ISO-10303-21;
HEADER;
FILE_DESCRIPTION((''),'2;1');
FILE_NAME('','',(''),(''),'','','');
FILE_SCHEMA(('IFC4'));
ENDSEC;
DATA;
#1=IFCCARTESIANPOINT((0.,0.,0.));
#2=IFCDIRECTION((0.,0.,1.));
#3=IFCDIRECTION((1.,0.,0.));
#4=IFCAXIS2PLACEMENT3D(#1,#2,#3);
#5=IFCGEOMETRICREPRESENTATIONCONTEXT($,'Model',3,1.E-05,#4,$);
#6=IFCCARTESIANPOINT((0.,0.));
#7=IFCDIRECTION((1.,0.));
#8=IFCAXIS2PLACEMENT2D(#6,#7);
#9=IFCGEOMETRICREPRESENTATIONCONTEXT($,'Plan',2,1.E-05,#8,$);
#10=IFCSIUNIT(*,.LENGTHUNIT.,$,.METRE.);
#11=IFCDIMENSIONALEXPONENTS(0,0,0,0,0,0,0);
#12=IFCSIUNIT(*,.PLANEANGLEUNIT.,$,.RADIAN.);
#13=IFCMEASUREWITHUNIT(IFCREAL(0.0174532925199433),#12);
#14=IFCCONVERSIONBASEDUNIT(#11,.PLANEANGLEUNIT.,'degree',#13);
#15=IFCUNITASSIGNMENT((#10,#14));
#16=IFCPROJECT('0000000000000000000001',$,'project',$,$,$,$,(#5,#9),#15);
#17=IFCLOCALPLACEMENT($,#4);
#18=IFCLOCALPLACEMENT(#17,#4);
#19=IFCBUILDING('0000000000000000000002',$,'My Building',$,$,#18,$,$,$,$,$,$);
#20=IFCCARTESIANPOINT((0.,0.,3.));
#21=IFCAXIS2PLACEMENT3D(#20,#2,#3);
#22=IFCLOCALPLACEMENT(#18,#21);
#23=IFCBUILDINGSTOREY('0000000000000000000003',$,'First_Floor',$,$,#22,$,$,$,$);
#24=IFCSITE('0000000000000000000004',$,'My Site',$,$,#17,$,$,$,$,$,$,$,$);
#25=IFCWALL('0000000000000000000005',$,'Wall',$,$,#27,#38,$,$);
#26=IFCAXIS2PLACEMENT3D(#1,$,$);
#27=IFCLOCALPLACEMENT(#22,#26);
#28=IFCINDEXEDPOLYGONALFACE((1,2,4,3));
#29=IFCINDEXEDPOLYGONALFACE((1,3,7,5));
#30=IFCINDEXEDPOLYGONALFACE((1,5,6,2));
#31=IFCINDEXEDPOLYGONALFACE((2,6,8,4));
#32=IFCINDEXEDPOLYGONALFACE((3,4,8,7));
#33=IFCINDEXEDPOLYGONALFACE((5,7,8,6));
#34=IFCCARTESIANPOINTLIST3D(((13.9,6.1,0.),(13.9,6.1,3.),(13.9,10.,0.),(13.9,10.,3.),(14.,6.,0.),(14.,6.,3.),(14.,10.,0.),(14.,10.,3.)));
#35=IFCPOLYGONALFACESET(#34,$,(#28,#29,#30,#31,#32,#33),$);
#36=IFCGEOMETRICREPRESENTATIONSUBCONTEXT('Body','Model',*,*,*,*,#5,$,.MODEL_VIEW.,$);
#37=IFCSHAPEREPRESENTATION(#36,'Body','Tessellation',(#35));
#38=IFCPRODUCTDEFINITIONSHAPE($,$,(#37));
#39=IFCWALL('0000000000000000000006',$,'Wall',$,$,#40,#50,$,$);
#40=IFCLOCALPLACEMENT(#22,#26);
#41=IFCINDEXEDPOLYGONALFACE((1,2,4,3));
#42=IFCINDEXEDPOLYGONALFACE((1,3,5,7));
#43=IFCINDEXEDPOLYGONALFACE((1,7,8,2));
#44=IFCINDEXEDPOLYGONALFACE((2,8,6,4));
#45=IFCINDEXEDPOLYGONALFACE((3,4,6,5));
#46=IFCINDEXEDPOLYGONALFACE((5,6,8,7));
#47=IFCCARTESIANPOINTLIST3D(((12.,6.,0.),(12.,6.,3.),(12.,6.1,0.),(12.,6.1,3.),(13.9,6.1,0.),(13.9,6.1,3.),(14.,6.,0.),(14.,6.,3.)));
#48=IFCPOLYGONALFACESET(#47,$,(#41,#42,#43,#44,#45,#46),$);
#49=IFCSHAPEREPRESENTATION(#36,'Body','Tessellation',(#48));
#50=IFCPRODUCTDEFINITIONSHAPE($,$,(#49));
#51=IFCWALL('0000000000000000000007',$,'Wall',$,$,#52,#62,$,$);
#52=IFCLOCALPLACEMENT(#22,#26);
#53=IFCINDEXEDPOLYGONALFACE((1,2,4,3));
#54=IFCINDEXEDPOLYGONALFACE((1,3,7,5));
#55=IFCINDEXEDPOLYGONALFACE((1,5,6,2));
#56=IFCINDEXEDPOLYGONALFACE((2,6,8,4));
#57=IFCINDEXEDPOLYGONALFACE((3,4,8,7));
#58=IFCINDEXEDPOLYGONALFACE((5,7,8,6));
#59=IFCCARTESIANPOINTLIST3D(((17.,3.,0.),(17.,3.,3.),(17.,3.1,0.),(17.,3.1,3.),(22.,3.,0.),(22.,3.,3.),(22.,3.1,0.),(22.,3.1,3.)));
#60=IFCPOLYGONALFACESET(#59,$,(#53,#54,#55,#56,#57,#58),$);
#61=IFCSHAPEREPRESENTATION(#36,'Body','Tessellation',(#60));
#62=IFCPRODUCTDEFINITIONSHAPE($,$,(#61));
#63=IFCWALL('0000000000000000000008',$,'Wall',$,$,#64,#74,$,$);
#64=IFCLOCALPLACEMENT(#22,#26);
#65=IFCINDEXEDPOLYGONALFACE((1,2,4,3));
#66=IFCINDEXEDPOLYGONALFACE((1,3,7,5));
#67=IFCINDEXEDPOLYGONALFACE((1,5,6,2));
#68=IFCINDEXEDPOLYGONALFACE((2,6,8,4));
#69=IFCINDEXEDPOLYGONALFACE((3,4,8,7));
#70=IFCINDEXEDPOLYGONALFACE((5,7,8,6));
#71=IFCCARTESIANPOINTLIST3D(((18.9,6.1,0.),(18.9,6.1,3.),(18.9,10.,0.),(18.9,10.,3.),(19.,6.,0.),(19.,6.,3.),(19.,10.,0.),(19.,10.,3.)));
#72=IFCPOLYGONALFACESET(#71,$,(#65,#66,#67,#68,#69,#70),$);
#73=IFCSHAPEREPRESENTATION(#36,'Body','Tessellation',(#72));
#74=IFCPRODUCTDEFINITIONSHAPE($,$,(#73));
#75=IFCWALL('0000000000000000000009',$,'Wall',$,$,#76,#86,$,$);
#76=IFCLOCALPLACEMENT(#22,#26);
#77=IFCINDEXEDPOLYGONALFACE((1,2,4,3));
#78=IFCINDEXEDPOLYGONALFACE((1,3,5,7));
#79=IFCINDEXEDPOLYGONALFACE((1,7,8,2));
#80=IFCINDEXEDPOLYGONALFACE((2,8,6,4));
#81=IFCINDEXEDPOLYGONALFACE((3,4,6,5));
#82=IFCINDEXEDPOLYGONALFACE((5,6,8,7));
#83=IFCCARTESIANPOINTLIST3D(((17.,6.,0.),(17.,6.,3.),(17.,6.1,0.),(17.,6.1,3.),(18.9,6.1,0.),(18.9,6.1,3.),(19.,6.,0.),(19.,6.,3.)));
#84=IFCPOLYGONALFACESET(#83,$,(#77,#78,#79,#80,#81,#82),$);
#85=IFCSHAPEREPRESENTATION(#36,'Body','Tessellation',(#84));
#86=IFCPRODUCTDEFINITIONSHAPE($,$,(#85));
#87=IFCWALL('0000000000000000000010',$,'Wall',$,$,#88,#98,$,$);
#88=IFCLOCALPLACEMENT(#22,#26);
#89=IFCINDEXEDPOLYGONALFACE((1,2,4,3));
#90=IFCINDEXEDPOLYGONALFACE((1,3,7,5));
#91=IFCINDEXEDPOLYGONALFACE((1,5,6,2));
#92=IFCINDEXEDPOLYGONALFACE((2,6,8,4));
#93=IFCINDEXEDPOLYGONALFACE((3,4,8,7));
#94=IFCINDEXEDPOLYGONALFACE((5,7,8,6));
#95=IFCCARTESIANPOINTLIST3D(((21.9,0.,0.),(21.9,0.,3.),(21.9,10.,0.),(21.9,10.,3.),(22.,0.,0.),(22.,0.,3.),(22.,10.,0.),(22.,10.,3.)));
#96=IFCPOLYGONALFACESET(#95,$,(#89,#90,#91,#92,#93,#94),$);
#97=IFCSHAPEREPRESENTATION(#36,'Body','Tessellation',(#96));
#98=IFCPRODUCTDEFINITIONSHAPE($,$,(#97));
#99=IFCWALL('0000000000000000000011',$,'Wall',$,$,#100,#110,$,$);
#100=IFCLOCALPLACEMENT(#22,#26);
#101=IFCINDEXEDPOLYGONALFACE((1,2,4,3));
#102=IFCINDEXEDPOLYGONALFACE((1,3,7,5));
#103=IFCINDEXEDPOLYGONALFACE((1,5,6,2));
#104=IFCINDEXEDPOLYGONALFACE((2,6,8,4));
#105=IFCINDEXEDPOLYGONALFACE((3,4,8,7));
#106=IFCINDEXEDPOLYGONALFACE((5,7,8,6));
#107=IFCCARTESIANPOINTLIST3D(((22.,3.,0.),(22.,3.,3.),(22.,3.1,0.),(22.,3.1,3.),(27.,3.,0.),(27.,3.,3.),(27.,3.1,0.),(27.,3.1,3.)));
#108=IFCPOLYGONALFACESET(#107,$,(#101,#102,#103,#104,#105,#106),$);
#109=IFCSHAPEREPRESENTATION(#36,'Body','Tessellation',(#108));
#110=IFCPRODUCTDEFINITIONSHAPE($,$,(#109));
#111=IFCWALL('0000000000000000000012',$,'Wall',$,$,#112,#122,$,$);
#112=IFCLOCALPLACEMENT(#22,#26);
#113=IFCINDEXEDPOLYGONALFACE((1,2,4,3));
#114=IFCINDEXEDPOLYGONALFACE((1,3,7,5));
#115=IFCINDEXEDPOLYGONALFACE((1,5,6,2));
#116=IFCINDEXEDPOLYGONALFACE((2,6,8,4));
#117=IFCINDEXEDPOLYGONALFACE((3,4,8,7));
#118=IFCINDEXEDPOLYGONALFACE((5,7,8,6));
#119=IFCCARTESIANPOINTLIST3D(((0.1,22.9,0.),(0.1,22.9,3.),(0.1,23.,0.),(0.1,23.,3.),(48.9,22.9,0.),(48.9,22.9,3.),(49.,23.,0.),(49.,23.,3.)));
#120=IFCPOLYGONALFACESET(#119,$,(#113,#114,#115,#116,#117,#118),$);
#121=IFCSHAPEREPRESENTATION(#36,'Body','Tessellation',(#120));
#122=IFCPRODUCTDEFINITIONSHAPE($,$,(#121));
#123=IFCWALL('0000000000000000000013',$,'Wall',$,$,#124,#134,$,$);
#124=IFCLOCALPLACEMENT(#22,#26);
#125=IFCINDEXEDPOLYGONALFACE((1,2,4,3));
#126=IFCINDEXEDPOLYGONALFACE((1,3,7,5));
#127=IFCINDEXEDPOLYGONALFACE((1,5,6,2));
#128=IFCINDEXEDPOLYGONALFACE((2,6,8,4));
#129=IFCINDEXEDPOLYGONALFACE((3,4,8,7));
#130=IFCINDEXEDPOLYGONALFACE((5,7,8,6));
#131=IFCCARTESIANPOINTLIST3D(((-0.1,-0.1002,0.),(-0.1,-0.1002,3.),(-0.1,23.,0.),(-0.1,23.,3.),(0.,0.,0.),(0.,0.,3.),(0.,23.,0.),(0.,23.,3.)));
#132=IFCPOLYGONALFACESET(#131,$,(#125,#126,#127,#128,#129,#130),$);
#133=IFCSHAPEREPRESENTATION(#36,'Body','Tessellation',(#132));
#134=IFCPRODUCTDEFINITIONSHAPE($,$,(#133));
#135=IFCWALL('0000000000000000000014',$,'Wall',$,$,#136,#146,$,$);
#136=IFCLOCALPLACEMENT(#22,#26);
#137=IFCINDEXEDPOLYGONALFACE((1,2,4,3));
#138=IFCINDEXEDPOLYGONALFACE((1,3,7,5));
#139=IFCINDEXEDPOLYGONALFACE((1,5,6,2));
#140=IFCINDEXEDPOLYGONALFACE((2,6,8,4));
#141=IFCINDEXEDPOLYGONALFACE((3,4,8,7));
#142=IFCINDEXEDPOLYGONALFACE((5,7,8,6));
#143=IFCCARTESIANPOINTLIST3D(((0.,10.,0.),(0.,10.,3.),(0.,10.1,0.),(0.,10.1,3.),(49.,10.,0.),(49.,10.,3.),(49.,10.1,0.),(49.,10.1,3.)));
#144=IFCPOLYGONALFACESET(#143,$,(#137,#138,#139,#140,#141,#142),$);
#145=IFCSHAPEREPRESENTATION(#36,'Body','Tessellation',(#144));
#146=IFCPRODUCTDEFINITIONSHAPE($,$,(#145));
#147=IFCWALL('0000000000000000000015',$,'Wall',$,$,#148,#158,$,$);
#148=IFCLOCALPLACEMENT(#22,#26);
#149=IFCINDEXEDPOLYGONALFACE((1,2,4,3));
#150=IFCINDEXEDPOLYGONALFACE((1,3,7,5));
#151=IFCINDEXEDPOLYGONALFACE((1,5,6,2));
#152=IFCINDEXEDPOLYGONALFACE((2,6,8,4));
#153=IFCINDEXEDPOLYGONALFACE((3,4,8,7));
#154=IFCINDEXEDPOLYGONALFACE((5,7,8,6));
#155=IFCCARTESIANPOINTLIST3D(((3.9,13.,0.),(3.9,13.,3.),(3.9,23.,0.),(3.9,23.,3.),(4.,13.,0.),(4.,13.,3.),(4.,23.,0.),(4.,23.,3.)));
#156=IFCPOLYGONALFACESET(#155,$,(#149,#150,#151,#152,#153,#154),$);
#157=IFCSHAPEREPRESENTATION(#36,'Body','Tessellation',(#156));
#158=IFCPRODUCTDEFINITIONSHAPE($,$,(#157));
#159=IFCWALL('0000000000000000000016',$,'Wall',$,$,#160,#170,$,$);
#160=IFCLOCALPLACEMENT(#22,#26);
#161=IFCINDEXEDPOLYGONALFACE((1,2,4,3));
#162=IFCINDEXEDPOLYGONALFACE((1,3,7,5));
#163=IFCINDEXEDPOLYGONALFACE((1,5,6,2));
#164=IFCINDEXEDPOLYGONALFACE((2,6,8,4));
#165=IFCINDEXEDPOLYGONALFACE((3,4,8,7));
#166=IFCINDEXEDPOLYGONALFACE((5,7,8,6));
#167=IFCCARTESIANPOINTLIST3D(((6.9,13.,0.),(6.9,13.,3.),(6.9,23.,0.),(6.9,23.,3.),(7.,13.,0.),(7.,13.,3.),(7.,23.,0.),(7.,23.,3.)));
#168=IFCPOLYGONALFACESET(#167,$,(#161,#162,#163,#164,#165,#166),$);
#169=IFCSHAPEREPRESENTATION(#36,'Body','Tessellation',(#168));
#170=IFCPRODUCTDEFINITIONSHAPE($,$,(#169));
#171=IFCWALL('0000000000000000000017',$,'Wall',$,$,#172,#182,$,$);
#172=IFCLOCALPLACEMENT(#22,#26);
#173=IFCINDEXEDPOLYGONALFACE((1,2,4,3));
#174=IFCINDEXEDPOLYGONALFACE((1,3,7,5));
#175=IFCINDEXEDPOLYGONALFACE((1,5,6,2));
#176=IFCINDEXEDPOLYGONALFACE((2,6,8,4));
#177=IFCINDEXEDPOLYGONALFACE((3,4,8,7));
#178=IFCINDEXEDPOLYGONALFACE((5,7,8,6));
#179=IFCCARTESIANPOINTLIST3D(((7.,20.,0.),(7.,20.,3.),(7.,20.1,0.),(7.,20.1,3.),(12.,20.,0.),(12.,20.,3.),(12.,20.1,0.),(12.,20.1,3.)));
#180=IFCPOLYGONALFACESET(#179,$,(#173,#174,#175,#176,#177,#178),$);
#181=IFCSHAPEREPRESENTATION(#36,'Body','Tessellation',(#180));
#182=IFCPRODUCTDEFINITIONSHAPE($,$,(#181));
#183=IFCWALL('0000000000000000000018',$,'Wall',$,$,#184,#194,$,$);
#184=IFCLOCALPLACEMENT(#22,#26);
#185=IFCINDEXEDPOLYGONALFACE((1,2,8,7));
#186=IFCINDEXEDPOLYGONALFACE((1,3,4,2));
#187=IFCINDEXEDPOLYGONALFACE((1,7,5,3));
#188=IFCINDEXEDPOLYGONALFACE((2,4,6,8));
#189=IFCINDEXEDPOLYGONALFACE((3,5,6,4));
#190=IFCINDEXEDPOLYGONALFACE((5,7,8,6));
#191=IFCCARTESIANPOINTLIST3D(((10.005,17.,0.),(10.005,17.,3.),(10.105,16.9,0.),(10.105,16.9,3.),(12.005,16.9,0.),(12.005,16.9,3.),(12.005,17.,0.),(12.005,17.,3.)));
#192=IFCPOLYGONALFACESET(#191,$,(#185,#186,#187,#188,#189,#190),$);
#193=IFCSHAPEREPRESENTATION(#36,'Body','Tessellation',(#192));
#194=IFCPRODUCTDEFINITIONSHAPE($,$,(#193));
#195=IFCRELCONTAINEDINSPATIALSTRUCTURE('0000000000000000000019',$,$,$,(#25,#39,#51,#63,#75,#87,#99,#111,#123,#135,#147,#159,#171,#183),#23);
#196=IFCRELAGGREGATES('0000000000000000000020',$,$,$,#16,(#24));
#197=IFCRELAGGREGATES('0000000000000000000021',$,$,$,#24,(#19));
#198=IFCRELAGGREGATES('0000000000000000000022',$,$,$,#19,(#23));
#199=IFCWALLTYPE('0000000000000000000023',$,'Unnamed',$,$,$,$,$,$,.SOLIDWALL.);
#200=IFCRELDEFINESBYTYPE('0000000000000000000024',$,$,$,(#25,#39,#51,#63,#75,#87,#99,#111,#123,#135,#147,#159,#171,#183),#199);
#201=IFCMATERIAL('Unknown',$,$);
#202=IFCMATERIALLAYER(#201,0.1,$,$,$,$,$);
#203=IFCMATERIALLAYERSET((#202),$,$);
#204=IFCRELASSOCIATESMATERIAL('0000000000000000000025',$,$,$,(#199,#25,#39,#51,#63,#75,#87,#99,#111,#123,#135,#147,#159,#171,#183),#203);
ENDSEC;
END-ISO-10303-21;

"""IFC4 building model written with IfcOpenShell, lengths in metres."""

from ifc_helpers import new_model, entity, si_unit, converted_unit, frame, origin_with_axes, origin_2d_with_axis, place, context, subcontext, project, spatial, line, indexed_curve, outline, extrude, material, layer, layer_set, layer_usage, type_object, element, save


model = new_model("IFC4")

# Units and contexts
model_context = context("Model", 3, precision=1e-05, world=origin_with_axes())
plan_context = context("Plan", 2, precision=1e-05, world=origin_2d_with_axis())
body_context = subcontext(model_context, "Body", "Model", "MODEL_VIEW")
ifc_project = project(units=[si_unit("LENGTHUNIT", "METRE"), converted_unit("PLANEANGLEUNIT", "degree", entity("IfcReal", 0.0174532925199433), si_unit("PLANEANGLEUNIT", "RADIAN"), dimensions=[0, 0, 0, 0, 0, 0, 0])], contexts=[model_context, plan_context])

# Site, building, storey
site_placement = place(None, origin_with_axes())
site = spatial("IfcSite", under=ifc_project, at=site_placement, Name="My Site")
building_placement = place(site_placement, origin_with_axes())
building = spatial("IfcBuilding", under=site, at=building_placement, Name="My Building")
storey_placement = place(building_placement, frame((0.0, 0.0, 3.0), z_axis=(0.0, 0.0, 1.0), x_axis=(1.0, 0.0, 0.0)))
storey = spatial("IfcBuildingStorey", under=building, at=storey_placement, Name="First_Floor")

# Shared definitions
ifc_material = material(Name="Unknown")

# Walls
ifc_layer_1 = layer(ifc_material, 0.1)
ifc_layer_set_1 = layer_set([ifc_layer_1])
wall_type = type_object("IfcWallType", Name="Unnamed", PredefinedType="SOLIDWALL", material=ifc_layer_set_1)
ifc_layer_usage_1 = layer_usage(ifc_layer_set_1, "AXIS2", "POSITIVE", 0.0)
wall_1_placement = place(storey_placement, frame((14.0, 6.0, 0.0), z_axis=(0.0, 0.0, 1.0), x_axis=(0.0, 1.0, 0.0)))
element("IfcWall", 1, at=wall_1_placement, inside=storey, type_object=wall_type, material=ifc_layer_usage_1, Name="Wall", context=body_context, shape_type="SweptSolid", body=[
    extrude(outline(indexed_curve([(0.0, 0.0), (0.1, 0.1), (4.0, 0.1), (4.0, 0.0)], segments=[line(1, 2, 3, 4, 1)])), origin_with_axes(), (0.0, 0.0, 1.0), 3.0),
])
ifc_layer_usage_2 = layer_usage(ifc_layer_set_1, "AXIS2", "POSITIVE", 0.0)
wall_2_placement = place(storey_placement, frame((12.0, 6.0, 0.0), z_axis=(0.0, 0.0, 1.0), x_axis=(1.0, 0.0, 0.0)))
element("IfcWall", 2, at=wall_2_placement, inside=storey, type_object=wall_type, material=ifc_layer_usage_2, Name="Wall", context=body_context, shape_type="SweptSolid", body=[
    extrude(outline(indexed_curve([(0.0, 0.0), (0.0, 0.1), (1.9, 0.1), (2.0, 0.0)], segments=[line(1, 2, 3, 4, 1)])), origin_with_axes(), (0.0, 0.0, 1.0), 3.0),
])
ifc_layer_usage_3 = layer_usage(ifc_layer_set_1, "AXIS2", "POSITIVE", 0.0)
wall_3_placement = place(storey_placement, frame((17.0, 3.0, 0.0), z_axis=(0.0, 0.0, 1.0), x_axis=(1.0, 0.0, 0.0)))
element("IfcWall", 3, at=wall_3_placement, inside=storey, type_object=wall_type, material=ifc_layer_usage_3, Name="Wall", context=body_context, shape_type="SweptSolid", body=[
    extrude(outline(indexed_curve([(0.0, 0.0), (0.0, 0.1), (5.0, 0.1), (5.0, 0.0)], segments=[line(1, 2, 3, 4, 1)])), origin_with_axes(), (0.0, 0.0, 1.0), 3.0),
])
ifc_layer_usage_4 = layer_usage(ifc_layer_set_1, "AXIS2", "POSITIVE", 0.0)
wall_4_placement = place(storey_placement, frame((19.0, 6.0, 0.0), z_axis=(0.0, 0.0, 1.0), x_axis=(0.0, 1.0, 0.0)))
element("IfcWall", 4, at=wall_4_placement, inside=storey, type_object=wall_type, material=ifc_layer_usage_4, Name="Wall", context=body_context, shape_type="SweptSolid", body=[
    extrude(outline(indexed_curve([(0.0, 0.0), (0.1, 0.1), (4.0, 0.1), (4.0, 0.0)], segments=[line(1, 2, 3, 4, 1)])), origin_with_axes(), (0.0, 0.0, 1.0), 3.0),
])
ifc_layer_usage_5 = layer_usage(ifc_layer_set_1, "AXIS2", "POSITIVE", 0.0)
wall_5_placement = place(storey_placement, frame((17.0, 6.0, 0.0), z_axis=(0.0, 0.0, 1.0), x_axis=(1.0, 0.0, 0.0)))
element("IfcWall", 5, at=wall_5_placement, inside=storey, type_object=wall_type, material=ifc_layer_usage_5, Name="Wall", context=body_context, shape_type="SweptSolid", body=[
    extrude(outline(indexed_curve([(0.0, 0.0), (0.0, 0.1), (1.9, 0.1), (2.0, 0.0)], segments=[line(1, 2, 3, 4, 1)])), origin_with_axes(), (0.0, 0.0, 1.0), 3.0),
])
ifc_layer_usage_6 = layer_usage(ifc_layer_set_1, "AXIS2", "POSITIVE", 0.0)
wall_6_placement = place(storey_placement, frame((21.9, 10.0, 0.0), z_axis=(0.0, 0.0, 1.0), x_axis=(0.0, -1.0, 0.0)))
element("IfcWall", 6, at=wall_6_placement, inside=storey, type_object=wall_type, material=ifc_layer_usage_6, Name="Wall", context=body_context, shape_type="SweptSolid", body=[
    extrude(outline(indexed_curve([(0.0, 0.0), (0.0, 0.1), (10.0, 0.1), (10.0, 0.0)], segments=[line(1, 2, 3, 4, 1)])), origin_with_axes(), (0.0, 0.0, 1.0), 3.0),
])
ifc_layer_usage_7 = layer_usage(ifc_layer_set_1, "AXIS2", "POSITIVE", 0.0)
wall_7_placement = place(storey_placement, frame((22.0, 3.0, 0.0), z_axis=(0.0, 0.0, 1.0), x_axis=(1.0, 0.0, 0.0)))
element("IfcWall", 7, at=wall_7_placement, inside=storey, type_object=wall_type, material=ifc_layer_usage_7, Name="Wall", context=body_context, shape_type="SweptSolid", body=[
    extrude(outline(indexed_curve([(0.0, 0.0), (0.0, 0.1), (5.0, 0.1), (5.0, 0.0)], segments=[line(1, 2, 3, 4, 1)])), origin_with_axes(), (0.0, 0.0, 1.0), 3.0),
])
ifc_layer_usage_8 = layer_usage(ifc_layer_set_1, "AXIS2", "POSITIVE", 0.0)
wall_8_placement = place(storey_placement, frame((0.1, 22.9, 0.0), z_axis=(0.0, 0.0, 1.0), x_axis=(1.0, 0.0, 0.0)))
element("IfcWall", 8, at=wall_8_placement, inside=storey, type_object=wall_type, material=ifc_layer_usage_8, Name="Wall", context=body_context, shape_type="SweptSolid", body=[
    extrude(outline(indexed_curve([(0.0, 0.0), (0.0, 0.1), (48.9, 0.1), (48.8, 0.0)], segments=[line(1, 2, 3, 4, 1)])), origin_with_axes(), (0.0, 0.0, 1.0), 3.0),
])
ifc_layer_usage_9 = layer_usage(ifc_layer_set_1, "AXIS2", "POSITIVE", 0.0)
wall_9_placement = place(storey_placement, frame((0.0, 0.0, 0.0), z_axis=(0.0, 0.0, 1.0), x_axis=(0.0, 1.0, 0.0)))
element("IfcWall", 9, at=wall_9_placement, inside=storey, type_object=wall_type, material=ifc_layer_usage_9, Name="Wall", context=body_context, shape_type="SweptSolid", body=[
    extrude(outline(indexed_curve([(0.0, 0.0), (-0.1002, 0.1), (23.0, 0.1), (23.0, 0.0)], segments=[line(1, 2, 3, 4, 1)])), origin_with_axes(), (0.0, 0.0, 1.0), 3.0),
])
ifc_layer_usage_10 = layer_usage(ifc_layer_set_1, "AXIS2", "POSITIVE", 0.0)
wall_10_placement = place(storey_placement, frame((0.0, 10.0, 0.0), z_axis=(0.0, 0.0, 1.0), x_axis=(1.0, 0.0, 0.0)))
element("IfcWall", 10, at=wall_10_placement, inside=storey, type_object=wall_type, material=ifc_layer_usage_10, Name="Wall", context=body_context, shape_type="SweptSolid", body=[
    extrude(outline(indexed_curve([(0.0, 0.0), (0.0, 0.1), (49.0, 0.1), (49.0, 0.0)], segments=[line(1, 2, 3, 4, 1)])), origin_with_axes(), (0.0, 0.0, 1.0), 3.0),
])
ifc_layer_usage_11 = layer_usage(ifc_layer_set_1, "AXIS2", "POSITIVE", 0.0)
wall_11_placement = place(storey_placement, frame((3.9, 23.0, 0.0), z_axis=(0.0, 0.0, 1.0), x_axis=(0.0, -1.0, 0.0)))
element("IfcWall", 11, at=wall_11_placement, inside=storey, type_object=wall_type, material=ifc_layer_usage_11, Name="Wall", context=body_context, shape_type="SweptSolid", body=[
    extrude(outline(indexed_curve([(0.0, 0.0), (0.0, 0.1), (10.0, 0.1), (10.0, 0.0)], segments=[line(1, 2, 3, 4, 1)])), origin_with_axes(), (0.0, 0.0, 1.0), 3.0),
])
ifc_layer_usage_12 = layer_usage(ifc_layer_set_1, "AXIS2", "POSITIVE", 0.0)
wall_12_placement = place(storey_placement, frame((6.9, 23.0, 0.0), z_axis=(0.0, 0.0, 1.0), x_axis=(0.0, -1.0, 0.0)))
element("IfcWall", 12, at=wall_12_placement, inside=storey, type_object=wall_type, material=ifc_layer_usage_12, Name="Wall", context=body_context, shape_type="SweptSolid", body=[
    extrude(outline(indexed_curve([(0.0, 0.0), (0.0, 0.1), (10.0, 0.1), (10.0, 0.0)], segments=[line(1, 2, 3, 4, 1)])), origin_with_axes(), (0.0, 0.0, 1.0), 3.0),
])
ifc_layer_usage_13 = layer_usage(ifc_layer_set_1, "AXIS2", "POSITIVE", 0.0)
wall_13_placement = place(storey_placement, frame((7.0, 20.0, 0.0), z_axis=(0.0, 0.0, 1.0), x_axis=(1.0, 0.0, 0.0)))
element("IfcWall", 13, at=wall_13_placement, inside=storey, type_object=wall_type, material=ifc_layer_usage_13, Name="Wall", context=body_context, shape_type="SweptSolid", body=[
    extrude(outline(indexed_curve([(0.0, 0.0), (0.0, 0.1), (5.0, 0.1), (5.0, 0.0)], segments=[line(1, 2, 3, 4, 1)])), origin_with_axes(), (0.0, 0.0, 1.0), 3.0),
])
ifc_layer_usage_14 = layer_usage(ifc_layer_set_1, "AXIS2", "POSITIVE", 0.0)
wall_14_placement = place(storey_placement, frame((12.005, 17.0, 0.0), z_axis=(0.0, 0.0, 1.0), x_axis=(-1.0, 0.0, 0.0)))
element("IfcWall", 14, at=wall_14_placement, inside=storey, type_object=wall_type, material=ifc_layer_usage_14, Name="Wall", context=body_context, shape_type="SweptSolid", body=[
    extrude(outline(indexed_curve([(0.0, 0.0), (0.0, 0.1), (1.9, 0.1), (2.0, 0.0)], segments=[line(1, 2, 3, 4, 1)])), origin_with_axes(), (0.0, 0.0, 1.0), 3.0),
])

save(model, "model.ifc")
